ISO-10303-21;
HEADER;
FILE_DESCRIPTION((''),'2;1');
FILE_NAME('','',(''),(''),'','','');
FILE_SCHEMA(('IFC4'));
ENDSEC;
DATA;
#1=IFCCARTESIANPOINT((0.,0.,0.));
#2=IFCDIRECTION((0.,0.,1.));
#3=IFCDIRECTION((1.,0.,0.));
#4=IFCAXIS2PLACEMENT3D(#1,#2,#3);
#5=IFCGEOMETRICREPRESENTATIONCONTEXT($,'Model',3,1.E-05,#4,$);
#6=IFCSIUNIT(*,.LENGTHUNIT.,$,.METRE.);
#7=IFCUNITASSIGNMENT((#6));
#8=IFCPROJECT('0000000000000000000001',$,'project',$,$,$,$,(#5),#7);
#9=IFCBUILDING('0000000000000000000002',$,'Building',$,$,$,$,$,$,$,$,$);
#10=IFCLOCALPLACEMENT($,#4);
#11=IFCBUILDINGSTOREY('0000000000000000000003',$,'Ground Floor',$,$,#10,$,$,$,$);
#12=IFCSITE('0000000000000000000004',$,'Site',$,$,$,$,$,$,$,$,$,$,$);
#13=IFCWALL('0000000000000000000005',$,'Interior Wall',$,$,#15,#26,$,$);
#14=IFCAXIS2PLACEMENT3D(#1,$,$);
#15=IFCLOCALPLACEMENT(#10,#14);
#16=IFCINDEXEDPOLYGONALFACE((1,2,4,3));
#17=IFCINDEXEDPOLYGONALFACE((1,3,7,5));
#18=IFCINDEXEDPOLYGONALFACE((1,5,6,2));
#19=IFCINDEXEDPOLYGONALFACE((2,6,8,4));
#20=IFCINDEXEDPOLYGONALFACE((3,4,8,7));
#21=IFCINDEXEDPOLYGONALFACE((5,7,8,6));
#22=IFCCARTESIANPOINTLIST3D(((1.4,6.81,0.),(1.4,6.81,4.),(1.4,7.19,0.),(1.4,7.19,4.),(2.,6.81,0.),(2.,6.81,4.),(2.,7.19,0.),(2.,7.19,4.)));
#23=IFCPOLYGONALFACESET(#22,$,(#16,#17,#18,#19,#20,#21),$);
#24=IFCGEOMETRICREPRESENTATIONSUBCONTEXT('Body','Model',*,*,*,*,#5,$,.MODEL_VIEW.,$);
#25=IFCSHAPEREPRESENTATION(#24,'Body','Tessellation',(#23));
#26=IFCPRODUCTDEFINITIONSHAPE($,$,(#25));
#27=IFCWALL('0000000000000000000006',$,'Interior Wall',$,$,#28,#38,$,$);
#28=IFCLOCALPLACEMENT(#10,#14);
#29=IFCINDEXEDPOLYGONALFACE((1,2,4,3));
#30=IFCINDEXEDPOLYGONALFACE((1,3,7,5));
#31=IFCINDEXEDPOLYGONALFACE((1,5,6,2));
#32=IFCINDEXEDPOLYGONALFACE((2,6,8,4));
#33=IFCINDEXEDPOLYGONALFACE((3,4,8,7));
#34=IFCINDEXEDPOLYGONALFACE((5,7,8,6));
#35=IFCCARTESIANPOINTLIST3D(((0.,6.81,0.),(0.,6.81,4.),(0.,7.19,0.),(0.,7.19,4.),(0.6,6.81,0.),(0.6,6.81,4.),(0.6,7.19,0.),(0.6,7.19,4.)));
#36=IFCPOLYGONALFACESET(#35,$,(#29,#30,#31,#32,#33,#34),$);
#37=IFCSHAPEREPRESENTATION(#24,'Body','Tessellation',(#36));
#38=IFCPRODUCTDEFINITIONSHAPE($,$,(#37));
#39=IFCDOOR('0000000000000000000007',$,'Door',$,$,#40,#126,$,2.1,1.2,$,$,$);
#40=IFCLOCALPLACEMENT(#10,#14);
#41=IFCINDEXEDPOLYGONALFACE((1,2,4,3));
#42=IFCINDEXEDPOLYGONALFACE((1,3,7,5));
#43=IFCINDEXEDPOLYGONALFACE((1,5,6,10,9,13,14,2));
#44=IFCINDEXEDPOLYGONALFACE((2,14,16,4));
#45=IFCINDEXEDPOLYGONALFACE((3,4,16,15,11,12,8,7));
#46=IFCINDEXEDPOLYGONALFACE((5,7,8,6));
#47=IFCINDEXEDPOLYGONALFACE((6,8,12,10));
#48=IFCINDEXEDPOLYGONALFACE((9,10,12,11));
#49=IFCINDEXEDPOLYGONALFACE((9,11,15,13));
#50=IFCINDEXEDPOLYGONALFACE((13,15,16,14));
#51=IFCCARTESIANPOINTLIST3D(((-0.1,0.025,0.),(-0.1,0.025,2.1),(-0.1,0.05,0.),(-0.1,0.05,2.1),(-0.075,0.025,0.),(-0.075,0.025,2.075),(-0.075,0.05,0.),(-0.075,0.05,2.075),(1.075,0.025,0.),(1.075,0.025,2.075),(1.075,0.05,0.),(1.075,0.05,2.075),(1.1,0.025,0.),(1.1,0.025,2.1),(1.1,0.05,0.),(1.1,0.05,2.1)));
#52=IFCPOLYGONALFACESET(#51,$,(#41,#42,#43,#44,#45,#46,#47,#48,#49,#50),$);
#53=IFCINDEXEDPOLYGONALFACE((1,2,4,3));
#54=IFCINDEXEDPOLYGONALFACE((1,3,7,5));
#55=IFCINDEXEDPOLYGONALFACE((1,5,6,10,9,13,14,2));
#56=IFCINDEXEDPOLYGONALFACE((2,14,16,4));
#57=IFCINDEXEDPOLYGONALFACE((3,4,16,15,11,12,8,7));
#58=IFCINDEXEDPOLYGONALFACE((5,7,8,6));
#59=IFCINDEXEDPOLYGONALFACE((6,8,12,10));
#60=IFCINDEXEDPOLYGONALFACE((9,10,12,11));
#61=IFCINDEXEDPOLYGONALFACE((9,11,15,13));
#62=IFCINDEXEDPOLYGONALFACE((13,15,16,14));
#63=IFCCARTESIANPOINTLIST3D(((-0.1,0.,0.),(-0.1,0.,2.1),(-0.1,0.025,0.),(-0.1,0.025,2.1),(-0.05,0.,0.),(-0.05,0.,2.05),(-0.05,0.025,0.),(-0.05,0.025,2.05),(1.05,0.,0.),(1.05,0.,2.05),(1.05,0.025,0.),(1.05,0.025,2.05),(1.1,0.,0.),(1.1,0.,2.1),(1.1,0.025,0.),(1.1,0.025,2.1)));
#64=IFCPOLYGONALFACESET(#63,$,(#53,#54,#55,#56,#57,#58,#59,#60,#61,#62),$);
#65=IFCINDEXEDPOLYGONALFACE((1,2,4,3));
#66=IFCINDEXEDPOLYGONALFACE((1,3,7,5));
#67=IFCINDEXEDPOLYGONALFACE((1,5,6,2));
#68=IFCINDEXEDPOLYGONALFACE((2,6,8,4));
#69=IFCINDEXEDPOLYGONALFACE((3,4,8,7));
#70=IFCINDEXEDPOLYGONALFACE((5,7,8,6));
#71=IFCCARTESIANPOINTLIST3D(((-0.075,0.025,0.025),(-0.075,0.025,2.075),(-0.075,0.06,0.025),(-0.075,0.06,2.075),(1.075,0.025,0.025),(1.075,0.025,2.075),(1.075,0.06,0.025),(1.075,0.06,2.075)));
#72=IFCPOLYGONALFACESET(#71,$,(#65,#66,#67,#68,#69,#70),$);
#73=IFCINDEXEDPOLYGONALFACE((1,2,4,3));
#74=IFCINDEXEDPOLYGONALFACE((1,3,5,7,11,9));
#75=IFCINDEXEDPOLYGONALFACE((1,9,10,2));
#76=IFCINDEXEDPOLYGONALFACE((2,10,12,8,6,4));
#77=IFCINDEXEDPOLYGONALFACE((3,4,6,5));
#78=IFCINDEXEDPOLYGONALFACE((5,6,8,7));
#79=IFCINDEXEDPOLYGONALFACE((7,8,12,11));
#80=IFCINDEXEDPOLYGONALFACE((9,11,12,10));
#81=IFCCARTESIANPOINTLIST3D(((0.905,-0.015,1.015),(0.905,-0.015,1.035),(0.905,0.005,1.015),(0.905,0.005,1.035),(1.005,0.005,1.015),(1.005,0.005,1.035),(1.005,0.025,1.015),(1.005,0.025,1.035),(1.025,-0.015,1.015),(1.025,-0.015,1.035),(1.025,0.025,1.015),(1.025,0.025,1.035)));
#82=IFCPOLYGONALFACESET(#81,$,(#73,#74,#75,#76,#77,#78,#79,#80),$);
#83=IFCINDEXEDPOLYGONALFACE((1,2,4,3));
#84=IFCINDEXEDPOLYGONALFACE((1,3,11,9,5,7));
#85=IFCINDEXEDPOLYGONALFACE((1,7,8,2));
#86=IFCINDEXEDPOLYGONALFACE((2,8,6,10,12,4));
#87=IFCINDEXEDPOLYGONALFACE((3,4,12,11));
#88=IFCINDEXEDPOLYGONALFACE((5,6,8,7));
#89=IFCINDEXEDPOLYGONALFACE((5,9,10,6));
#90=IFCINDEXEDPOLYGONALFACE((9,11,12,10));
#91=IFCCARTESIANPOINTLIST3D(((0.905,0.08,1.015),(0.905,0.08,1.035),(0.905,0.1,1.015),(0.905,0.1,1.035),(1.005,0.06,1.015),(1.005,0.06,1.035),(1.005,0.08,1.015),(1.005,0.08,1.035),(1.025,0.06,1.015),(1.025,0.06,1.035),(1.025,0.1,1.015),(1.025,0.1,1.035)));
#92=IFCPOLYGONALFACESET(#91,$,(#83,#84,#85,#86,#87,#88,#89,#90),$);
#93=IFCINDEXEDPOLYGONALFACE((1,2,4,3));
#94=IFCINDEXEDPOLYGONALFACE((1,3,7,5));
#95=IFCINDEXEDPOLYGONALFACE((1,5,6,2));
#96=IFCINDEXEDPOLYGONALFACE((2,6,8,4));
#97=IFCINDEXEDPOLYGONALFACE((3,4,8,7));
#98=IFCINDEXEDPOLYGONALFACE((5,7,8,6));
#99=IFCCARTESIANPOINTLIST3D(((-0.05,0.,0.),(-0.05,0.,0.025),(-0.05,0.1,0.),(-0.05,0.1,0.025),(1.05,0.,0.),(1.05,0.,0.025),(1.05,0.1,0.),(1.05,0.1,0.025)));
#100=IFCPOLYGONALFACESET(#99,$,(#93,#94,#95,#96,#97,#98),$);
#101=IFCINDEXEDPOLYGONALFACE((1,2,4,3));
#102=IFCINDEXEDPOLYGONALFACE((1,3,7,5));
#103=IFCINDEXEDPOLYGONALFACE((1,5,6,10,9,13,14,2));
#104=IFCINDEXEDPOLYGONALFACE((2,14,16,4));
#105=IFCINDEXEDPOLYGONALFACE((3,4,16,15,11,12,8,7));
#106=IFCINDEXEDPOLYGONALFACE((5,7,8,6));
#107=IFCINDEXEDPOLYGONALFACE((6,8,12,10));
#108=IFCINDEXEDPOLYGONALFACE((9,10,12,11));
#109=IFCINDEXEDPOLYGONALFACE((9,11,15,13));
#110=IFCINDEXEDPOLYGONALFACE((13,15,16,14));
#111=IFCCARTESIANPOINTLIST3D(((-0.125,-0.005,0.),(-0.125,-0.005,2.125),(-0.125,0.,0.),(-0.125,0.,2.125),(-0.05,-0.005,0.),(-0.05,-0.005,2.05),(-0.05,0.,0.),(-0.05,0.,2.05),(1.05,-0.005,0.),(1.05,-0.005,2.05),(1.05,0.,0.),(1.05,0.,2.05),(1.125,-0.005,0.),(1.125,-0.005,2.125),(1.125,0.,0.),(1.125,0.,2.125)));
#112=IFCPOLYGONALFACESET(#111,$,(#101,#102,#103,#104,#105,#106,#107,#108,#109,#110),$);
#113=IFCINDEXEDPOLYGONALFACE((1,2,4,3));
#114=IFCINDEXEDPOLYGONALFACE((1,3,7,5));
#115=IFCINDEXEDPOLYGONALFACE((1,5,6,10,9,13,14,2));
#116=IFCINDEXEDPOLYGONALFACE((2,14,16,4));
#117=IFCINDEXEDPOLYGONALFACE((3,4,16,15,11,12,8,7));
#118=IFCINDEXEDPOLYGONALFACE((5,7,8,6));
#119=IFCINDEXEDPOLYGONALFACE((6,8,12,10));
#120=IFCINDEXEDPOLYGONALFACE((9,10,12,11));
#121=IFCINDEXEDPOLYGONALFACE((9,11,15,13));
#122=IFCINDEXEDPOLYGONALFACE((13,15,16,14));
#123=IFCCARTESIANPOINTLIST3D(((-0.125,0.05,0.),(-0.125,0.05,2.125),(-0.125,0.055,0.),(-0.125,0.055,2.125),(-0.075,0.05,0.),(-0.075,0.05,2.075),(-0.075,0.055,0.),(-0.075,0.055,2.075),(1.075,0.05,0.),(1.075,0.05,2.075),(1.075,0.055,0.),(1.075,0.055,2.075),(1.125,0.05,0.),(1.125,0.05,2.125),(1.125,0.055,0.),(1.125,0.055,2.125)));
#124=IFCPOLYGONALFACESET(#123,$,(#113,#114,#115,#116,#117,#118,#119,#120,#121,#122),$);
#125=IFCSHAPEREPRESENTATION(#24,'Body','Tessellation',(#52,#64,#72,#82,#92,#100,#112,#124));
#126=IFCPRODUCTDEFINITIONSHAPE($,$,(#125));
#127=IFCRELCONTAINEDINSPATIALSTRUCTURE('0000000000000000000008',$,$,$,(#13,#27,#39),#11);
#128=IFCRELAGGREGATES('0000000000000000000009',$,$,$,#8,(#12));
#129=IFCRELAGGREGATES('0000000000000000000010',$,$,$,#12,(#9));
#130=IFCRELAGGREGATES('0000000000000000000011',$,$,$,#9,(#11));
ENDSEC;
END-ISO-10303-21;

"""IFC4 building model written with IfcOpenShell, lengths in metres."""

from ifc_helpers import new_model, si_unit, frame, origin_with_axes, place, context, subcontext, project, spatial, line, indexed_curve, outline, extrude, element, save


model = new_model("IFC4")

# Units and contexts
model_context = context("Model", 3, precision=1e-05, world=origin_with_axes())
body_context = subcontext(model_context, "Body", "Model", "MODEL_VIEW")
ifc_project = project(units=[si_unit("LENGTHUNIT", "METRE")], contexts=[model_context])

# Site, building, storey
site = spatial("IfcSite", under=ifc_project, Name="Site")
building = spatial("IfcBuilding", under=site, Name="Building")
storey_placement = place(None, origin_with_axes())
storey = spatial("IfcBuildingStorey", under=building, at=storey_placement, Name="Ground Floor")

# Walls
for number, where, z_axis, x_axis, name in (
    (1, (2.0, 7.0, 0.0), (0.0, 0.0, 1.0), (-1.0, 0.0, 0.0), "Interior Wall"),
    (2, (0.6, 7.0, 0.0), (0.0, 0.0, 1.0), (-1.0, 0.0, 0.0), "Interior Wall"),
):
    element("IfcWall", number, at=place(storey_placement, frame(where, z_axis=z_axis, x_axis=x_axis)), inside=storey, Name=name, context=body_context, shape_type="SweptSolid", body=[
        extrude(outline(indexed_curve([(0.0, 0.0), (0.0, 0.38), (0.6, 0.38), (0.6, 0.0), (0.0, 0.0)], self_intersect=False)), frame((0.0, -0.19, 0.0), z_axis=(0.0, 0.0, 1.0), x_axis=(1.0, 0.0, 0.0)), (0.0, 0.0, 1.0), 4.0),
    ])

# Door
door_1_placement = place(storey_placement, frame((-0.1, 0.0, 0.0), z_axis=(0.0, 0.0, 1.0), x_axis=(1.0, 0.0, 0.0)))
element("IfcDoor", 3, at=door_1_placement, inside=storey, Name="Door", OverallHeight=2.1, OverallWidth=1.2, context=body_context, shape_type="SweptSolid", body=[
    extrude(outline(indexed_curve([(0.0, 0.0), (0.0, 2.1), (1.2, 2.1), (1.2, 0.0), (1.175, 0.0), (1.175, 2.075), (0.025, 2.075), (0.025, 0.0)], segments=[line(1, 2, 3, 4, 5, 6, 7, 8, 1)])), frame((0.0, 0.025, 0.0), z_axis=(0.0, -1.0, 0.0), x_axis=(1.0, 0.0, 0.0)), (0.0, 0.0, -1.0), 0.025),
    extrude(outline(indexed_curve([(0.0, 0.0), (0.0, 2.1), (1.2, 2.1), (1.2, 0.0), (1.15, 0.0), (1.15, 2.05), (0.05, 2.05), (0.05, 0.0)], segments=[line(1, 2, 3, 4, 5, 6, 7, 8, 1)])), frame((0.0, 0.0, 0.0), z_axis=(0.0, -1.0, 0.0), x_axis=(1.0, 0.0, 0.0)), (0.0, 0.0, -1.0), 0.025),
    extrude(outline(indexed_curve([(0.0, 0.0), (1.15, 0.0), (1.15, 0.035), (0.0, 0.035)], segments=[line(1, 2, 3, 4, 1)])), frame((0.025, 0.025, 0.025), z_axis=(0.0, 0.0, 1.0), x_axis=(1.0, 0.0, 0.0)), (0.0, 0.0, 1.0), 2.05),
    extrude(outline(indexed_curve([(0.0, 0.0), (0.0, -0.04), (-0.12, -0.04), (-0.12, -0.02), (-0.02, -0.02), (-0.02, 0.0)], segments=[line(1, 2, 3, 4, 5, 6, 1)])), frame((1.125, 0.025, 1.015), z_axis=(0.0, 0.0, 1.0), x_axis=(1.0, 0.0, 0.0)), (0.0, 0.0, 1.0), 0.02),
    extrude(outline(indexed_curve([(0.0, 0.0), (0.0, 0.04), (-0.12, 0.04), (-0.12, 0.02), (-0.02, 0.02), (-0.02, 0.0)], segments=[line(1, 2, 3, 4, 5, 6, 1)])), frame((1.125, 0.06, 1.015), z_axis=(0.0, 0.0, 1.0), x_axis=(1.0, 0.0, 0.0)), (0.0, 0.0, 1.0), 0.02),
    extrude(outline(indexed_curve([(0.0, 0.0), (1.1, 0.0), (1.1, 0.1), (0.0, 0.1)], segments=[line(1, 2, 3, 4, 1)])), frame((0.05, 0.0, 0.0), z_axis=(0.0, 0.0, 1.0), x_axis=(1.0, 0.0, 0.0)), (0.0, 0.0, 1.0), 0.025),
    extrude(outline(indexed_curve([(0.0, 0.0), (0.0, 2.125), (1.25, 2.125), (1.25, 0.0), (1.175, 0.0), (1.175, 2.05), (0.075, 2.05), (0.075, 0.0)], segments=[line(1, 2, 3, 4, 5, 6, 7, 8, 1)])), frame((-0.025, -0.005, 0.0), z_axis=(0.0, -1.0, 0.0), x_axis=(1.0, 0.0, 0.0)), (0.0, 0.0, -1.0), 0.005),
    extrude(outline(indexed_curve([(0.0, 0.0), (0.0, 2.125), (1.25, 2.125), (1.25, 0.0), (1.2, 0.0), (1.2, 2.075), (0.05, 2.075), (0.05, 0.0)], segments=[line(1, 2, 3, 4, 5, 6, 7, 8, 1)])), frame((-0.025, 0.05, 0.0), z_axis=(0.0, -1.0, 0.0), x_axis=(1.0, 0.0, 0.0)), (0.0, 0.0, -1.0), 0.005),
])

save(model, "model.ifc")
